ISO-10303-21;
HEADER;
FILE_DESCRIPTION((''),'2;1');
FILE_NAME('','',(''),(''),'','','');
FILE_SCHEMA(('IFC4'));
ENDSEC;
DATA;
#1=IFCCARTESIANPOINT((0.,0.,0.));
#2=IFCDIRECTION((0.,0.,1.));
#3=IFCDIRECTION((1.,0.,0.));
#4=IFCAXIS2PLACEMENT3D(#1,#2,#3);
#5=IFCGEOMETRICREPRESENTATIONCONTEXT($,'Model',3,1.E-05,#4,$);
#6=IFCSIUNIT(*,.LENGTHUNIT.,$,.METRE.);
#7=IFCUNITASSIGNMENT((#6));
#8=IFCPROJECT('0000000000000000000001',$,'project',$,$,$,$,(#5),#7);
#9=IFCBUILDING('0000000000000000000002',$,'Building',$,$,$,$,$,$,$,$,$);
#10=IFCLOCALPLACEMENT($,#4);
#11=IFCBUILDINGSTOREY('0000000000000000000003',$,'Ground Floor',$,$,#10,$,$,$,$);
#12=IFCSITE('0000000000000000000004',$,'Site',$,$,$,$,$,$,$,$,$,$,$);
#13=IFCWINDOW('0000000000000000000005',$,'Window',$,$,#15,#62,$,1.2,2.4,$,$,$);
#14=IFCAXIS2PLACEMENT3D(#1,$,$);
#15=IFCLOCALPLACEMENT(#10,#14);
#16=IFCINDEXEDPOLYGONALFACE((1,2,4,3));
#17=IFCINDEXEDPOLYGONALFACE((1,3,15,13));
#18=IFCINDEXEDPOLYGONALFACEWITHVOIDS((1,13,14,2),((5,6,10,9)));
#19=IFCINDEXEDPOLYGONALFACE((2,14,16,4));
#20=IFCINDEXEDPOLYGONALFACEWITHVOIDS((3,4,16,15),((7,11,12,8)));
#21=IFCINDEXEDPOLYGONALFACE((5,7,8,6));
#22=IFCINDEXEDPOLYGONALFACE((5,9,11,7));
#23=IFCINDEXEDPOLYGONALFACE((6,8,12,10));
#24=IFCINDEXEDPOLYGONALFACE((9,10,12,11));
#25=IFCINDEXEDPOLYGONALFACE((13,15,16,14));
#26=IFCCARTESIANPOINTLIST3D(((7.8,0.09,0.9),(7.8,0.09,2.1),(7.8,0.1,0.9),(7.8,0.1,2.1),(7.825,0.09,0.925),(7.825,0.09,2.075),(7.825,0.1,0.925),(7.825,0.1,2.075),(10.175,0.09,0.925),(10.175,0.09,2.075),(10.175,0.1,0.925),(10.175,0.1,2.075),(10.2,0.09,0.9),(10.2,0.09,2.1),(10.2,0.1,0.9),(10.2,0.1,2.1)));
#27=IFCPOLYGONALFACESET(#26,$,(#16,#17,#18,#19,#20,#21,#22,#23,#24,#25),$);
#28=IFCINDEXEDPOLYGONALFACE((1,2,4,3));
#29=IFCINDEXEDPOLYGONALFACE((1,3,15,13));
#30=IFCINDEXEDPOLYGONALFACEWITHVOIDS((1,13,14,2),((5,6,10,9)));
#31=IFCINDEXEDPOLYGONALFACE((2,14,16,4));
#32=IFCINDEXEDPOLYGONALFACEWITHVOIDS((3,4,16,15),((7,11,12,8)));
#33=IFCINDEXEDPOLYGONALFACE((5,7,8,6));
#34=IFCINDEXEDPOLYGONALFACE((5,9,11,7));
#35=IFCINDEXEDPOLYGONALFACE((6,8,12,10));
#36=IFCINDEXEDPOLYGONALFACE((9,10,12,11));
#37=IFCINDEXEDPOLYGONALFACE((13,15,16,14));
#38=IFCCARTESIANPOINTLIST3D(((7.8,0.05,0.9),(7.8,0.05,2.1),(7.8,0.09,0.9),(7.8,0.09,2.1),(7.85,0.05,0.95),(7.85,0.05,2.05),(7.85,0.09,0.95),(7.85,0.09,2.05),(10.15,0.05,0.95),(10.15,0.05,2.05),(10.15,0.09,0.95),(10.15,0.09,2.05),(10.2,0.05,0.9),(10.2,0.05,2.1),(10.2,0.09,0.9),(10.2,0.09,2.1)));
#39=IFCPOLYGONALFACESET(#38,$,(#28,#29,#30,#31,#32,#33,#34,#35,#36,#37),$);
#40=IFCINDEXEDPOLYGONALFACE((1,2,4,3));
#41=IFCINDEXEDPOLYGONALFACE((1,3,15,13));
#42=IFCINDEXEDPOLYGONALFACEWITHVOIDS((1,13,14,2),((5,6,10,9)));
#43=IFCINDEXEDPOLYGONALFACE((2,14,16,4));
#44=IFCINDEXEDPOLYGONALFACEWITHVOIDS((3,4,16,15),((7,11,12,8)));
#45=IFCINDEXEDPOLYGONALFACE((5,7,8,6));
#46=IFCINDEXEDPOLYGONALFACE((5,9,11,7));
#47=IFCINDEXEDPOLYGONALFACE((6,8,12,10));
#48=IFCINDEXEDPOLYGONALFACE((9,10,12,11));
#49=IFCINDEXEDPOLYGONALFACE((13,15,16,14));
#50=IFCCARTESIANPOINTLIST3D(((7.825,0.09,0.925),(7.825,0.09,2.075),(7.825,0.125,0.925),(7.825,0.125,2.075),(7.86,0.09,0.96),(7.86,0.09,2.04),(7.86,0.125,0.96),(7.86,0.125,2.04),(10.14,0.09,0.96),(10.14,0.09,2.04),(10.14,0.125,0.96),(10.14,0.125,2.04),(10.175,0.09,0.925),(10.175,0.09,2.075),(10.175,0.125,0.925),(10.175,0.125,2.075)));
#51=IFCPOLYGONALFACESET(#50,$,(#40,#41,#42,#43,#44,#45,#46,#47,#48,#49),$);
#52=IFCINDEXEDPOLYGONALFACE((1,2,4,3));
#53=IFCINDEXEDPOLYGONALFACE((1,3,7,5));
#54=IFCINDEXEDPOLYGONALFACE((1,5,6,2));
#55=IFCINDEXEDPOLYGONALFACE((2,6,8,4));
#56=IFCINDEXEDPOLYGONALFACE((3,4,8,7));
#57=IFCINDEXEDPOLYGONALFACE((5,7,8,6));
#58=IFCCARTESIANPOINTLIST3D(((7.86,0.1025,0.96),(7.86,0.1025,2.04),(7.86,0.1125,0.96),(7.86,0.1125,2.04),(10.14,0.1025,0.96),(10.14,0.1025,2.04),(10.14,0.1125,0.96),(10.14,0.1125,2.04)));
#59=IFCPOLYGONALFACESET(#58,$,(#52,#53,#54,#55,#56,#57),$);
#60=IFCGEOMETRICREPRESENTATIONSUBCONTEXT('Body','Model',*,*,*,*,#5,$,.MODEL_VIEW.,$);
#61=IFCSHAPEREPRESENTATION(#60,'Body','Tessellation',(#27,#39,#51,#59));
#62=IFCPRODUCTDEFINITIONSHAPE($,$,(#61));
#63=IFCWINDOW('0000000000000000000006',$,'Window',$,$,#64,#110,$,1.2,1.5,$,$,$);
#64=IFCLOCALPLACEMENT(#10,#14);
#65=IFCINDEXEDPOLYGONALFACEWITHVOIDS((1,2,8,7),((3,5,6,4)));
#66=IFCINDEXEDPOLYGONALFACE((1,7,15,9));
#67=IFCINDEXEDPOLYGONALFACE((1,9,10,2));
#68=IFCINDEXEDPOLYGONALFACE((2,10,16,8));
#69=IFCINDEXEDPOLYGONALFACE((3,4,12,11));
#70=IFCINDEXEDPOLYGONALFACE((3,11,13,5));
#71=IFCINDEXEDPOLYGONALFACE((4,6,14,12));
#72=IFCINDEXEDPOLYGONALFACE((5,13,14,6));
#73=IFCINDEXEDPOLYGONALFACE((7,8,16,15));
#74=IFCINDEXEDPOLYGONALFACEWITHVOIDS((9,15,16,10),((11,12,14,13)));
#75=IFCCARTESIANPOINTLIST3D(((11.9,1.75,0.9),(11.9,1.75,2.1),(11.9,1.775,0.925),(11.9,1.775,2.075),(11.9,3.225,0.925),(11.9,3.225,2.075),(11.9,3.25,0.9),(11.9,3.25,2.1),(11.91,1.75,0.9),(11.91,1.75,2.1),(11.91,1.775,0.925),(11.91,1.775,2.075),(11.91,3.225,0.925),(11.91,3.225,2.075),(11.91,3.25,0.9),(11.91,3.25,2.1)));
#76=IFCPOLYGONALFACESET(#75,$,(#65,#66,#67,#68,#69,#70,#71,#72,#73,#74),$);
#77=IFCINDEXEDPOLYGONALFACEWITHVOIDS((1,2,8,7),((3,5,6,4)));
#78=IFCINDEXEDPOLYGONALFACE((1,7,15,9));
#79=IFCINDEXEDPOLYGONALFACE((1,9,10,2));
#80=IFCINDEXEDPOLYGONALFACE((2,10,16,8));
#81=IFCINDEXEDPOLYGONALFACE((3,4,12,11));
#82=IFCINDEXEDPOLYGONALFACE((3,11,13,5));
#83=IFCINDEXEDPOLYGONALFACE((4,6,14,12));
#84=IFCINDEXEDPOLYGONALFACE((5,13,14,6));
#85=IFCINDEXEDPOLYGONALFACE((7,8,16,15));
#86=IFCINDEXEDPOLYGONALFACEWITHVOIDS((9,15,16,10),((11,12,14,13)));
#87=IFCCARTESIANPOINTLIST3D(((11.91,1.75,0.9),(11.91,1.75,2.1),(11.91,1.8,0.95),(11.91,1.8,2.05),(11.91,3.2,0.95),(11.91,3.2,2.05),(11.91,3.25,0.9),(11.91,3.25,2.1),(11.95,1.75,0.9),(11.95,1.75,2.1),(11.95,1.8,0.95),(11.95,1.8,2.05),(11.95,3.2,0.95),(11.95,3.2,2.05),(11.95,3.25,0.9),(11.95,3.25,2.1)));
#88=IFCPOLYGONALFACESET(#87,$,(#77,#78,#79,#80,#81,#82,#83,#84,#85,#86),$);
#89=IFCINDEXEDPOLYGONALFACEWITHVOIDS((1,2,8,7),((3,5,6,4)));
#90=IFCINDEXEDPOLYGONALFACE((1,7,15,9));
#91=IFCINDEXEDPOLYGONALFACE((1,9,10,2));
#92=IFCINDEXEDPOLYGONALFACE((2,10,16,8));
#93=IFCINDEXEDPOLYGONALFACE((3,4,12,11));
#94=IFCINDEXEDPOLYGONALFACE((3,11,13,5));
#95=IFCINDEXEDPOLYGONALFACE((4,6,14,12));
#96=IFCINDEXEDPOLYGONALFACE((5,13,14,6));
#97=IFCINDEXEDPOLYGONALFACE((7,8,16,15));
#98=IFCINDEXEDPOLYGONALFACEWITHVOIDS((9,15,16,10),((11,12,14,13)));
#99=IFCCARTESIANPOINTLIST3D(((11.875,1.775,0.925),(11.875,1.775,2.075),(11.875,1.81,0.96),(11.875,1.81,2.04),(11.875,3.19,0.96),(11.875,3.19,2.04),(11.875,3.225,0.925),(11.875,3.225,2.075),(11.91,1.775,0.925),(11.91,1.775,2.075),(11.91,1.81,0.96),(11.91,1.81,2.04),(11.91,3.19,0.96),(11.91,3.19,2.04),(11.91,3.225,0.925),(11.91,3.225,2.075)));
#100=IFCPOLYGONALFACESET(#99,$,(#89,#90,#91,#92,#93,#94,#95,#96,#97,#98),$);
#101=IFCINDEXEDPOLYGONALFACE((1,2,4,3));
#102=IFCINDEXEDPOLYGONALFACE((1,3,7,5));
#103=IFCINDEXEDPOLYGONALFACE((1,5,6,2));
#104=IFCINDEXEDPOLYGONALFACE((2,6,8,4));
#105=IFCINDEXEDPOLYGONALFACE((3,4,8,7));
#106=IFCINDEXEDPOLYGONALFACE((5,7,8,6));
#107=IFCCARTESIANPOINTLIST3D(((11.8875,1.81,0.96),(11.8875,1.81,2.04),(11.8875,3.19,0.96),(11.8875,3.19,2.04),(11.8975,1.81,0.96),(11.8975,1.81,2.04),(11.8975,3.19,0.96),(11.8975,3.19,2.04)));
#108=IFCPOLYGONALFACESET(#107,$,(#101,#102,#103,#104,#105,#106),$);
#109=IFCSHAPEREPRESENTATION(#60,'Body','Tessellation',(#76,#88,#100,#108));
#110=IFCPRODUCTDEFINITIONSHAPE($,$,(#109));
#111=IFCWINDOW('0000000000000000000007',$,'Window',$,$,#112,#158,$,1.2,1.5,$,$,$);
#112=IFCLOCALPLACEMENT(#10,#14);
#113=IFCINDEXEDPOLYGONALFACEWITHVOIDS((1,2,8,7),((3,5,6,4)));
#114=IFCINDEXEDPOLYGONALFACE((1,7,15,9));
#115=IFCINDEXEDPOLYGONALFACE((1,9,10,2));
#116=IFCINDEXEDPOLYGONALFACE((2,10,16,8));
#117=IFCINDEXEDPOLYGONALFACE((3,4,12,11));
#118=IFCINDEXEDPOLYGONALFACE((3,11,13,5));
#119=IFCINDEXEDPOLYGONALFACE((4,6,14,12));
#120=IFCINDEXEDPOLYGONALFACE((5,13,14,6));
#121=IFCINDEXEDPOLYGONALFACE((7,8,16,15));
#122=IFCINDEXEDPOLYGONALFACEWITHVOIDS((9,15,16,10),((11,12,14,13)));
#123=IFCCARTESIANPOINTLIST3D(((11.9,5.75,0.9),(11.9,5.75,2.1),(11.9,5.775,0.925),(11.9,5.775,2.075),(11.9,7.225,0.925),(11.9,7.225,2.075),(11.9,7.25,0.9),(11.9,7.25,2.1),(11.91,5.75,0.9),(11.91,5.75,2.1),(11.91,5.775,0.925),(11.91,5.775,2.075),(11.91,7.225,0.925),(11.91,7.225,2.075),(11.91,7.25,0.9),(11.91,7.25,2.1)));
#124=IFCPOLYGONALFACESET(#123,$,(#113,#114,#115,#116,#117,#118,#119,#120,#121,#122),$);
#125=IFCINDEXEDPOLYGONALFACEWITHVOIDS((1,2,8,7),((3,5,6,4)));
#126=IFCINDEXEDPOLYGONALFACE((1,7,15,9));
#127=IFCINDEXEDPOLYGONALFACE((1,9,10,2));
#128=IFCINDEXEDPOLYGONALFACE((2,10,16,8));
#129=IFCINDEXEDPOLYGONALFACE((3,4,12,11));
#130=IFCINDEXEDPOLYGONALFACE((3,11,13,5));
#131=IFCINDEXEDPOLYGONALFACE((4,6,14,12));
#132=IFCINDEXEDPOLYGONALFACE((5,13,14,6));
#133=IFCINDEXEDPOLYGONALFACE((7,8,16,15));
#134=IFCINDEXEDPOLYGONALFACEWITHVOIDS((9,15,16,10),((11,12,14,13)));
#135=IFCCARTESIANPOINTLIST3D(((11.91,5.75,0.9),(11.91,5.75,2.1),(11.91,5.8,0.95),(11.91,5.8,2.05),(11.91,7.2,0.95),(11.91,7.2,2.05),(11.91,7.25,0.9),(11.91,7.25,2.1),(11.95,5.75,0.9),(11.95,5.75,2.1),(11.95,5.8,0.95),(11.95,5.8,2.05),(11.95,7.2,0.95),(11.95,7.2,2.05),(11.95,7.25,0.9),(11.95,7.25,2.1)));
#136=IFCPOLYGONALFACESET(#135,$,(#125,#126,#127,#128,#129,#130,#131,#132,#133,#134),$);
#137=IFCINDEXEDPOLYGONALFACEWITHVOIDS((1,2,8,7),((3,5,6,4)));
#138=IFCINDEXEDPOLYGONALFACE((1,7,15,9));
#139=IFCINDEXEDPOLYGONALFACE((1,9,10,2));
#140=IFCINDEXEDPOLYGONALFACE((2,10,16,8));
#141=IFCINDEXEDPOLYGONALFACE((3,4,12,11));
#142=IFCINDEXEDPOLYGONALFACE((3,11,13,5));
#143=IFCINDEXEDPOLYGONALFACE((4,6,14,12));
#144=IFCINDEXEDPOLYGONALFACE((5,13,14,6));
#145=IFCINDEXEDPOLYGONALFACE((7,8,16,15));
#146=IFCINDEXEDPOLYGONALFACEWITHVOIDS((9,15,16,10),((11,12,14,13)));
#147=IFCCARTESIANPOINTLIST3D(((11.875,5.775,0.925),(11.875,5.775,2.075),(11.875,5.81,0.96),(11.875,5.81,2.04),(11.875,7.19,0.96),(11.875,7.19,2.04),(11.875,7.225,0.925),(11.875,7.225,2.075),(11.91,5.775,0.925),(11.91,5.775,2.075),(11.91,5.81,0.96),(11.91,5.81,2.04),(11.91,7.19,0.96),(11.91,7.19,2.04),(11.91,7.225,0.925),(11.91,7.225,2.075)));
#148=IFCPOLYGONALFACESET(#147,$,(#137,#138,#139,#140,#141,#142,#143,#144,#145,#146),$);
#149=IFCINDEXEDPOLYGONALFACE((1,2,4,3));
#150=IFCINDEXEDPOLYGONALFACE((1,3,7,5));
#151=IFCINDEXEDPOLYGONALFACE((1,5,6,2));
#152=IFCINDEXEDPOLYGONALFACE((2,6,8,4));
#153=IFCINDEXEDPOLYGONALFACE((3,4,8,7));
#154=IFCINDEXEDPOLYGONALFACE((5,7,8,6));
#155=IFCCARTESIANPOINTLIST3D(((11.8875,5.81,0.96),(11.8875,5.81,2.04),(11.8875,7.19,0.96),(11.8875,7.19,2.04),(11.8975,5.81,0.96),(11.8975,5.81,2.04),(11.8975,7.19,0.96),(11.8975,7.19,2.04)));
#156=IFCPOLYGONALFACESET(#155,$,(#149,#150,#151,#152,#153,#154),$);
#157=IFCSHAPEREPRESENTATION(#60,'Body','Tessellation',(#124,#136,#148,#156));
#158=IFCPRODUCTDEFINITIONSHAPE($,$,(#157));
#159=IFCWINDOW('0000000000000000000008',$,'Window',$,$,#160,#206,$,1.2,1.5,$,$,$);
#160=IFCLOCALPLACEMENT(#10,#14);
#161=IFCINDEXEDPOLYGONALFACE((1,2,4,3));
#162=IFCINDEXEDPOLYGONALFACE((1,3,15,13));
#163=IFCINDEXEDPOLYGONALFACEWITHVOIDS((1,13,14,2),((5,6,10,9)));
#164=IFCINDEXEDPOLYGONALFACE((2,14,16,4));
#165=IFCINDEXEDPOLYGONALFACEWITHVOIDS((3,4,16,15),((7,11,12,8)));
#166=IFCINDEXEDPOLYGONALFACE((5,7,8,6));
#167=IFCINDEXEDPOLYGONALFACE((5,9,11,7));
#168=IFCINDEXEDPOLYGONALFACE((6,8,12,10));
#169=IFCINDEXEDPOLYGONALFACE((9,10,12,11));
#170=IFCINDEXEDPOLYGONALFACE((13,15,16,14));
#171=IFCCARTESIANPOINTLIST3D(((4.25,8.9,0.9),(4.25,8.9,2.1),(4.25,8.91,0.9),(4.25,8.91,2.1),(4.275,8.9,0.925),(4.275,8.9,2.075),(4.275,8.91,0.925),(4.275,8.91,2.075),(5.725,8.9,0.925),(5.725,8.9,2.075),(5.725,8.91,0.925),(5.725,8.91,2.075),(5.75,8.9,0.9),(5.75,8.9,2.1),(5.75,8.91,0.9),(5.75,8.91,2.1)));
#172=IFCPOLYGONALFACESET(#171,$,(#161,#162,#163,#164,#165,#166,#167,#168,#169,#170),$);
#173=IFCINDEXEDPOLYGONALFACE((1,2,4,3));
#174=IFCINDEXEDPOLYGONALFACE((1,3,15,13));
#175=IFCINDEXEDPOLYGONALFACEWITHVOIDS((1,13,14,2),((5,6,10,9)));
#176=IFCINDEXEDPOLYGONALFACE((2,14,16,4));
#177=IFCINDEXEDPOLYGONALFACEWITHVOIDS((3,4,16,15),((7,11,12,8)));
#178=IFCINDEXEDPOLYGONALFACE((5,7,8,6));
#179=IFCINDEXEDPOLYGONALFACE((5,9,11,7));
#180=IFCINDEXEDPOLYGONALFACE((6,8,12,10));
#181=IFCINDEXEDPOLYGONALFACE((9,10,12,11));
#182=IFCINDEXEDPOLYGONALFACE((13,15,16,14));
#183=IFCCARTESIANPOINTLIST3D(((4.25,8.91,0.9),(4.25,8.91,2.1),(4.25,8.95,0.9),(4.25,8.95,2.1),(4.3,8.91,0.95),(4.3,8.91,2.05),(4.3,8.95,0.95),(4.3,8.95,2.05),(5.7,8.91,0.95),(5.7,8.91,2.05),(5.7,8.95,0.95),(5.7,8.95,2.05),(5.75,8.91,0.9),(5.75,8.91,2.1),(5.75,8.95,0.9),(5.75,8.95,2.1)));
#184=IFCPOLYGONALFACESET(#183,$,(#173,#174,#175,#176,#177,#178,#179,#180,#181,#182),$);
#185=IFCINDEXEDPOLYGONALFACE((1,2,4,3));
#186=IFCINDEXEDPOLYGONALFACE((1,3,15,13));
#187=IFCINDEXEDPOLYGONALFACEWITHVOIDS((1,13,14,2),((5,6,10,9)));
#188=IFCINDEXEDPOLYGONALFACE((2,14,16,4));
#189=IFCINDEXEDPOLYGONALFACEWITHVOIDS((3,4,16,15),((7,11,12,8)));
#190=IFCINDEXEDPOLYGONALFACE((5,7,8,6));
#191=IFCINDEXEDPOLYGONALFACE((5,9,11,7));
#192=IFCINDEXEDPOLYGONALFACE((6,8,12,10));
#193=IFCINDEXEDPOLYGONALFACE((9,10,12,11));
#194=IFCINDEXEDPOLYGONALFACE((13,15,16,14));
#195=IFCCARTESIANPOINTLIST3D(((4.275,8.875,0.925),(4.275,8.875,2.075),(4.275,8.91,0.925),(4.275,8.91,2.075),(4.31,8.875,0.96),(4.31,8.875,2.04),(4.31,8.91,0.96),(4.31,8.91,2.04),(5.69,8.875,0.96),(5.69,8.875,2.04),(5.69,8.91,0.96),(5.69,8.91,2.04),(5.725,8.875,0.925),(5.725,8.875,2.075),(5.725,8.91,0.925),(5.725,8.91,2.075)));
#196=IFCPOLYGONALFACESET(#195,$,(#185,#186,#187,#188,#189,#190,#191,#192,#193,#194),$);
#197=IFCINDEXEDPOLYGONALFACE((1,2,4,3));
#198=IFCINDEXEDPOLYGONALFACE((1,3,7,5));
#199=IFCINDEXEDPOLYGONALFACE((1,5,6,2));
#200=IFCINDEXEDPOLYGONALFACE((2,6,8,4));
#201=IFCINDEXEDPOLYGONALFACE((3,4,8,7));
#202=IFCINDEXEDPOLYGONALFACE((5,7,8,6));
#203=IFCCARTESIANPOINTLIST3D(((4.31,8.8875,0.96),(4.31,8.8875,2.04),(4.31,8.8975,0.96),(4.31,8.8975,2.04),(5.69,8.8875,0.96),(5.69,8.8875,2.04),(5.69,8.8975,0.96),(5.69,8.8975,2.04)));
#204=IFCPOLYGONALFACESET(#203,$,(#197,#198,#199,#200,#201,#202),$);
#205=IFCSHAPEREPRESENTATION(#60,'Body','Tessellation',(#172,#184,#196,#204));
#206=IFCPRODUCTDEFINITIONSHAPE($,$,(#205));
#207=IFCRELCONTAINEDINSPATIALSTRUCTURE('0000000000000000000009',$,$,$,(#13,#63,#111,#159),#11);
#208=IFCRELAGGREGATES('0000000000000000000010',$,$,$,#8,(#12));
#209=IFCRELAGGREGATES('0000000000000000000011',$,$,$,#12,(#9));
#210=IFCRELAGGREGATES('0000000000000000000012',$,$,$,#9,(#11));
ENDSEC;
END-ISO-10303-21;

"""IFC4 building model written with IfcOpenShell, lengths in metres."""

from ifc_helpers import new_model, si_unit, frame, origin_with_axes, place, context, subcontext, project, spatial, line, indexed_curve, outline, extrude, element, save


model = new_model("IFC4")

# Units and contexts
model_context = context("Model", 3, precision=1e-05, world=origin_with_axes())
body_context = subcontext(model_context, "Body", "Model", "MODEL_VIEW")
ifc_project = project(units=[si_unit("LENGTHUNIT", "METRE")], contexts=[model_context])

# Site, building, storey
site = spatial("IfcSite", under=ifc_project, Name="Site")
building = spatial("IfcBuilding", under=site, Name="Building")
storey_placement = place(None, origin_with_axes())
storey = spatial("IfcBuildingStorey", under=building, at=storey_placement, Name="Ground Floor")

# Windows
window_1_placement = place(storey_placement, frame((7.8, 0.0, 0.9), z_axis=(0.0, 0.0, 1.0), x_axis=(1.0, 0.0, 0.0)))
element("IfcWindow", 1, at=window_1_placement, inside=storey, Name="Window", OverallHeight=1.2, OverallWidth=2.4, context=body_context, shape_type="SweptSolid", body=[
    extrude(outline(indexed_curve([(0.0, 0.0), (2.4, 0.0), (2.4, 1.2), (0.0, 1.2)], segments=[line(1, 2, 3, 4, 1)]), holes=[indexed_curve([(0.025, 0.025), (2.375, 0.025), (2.375, 1.175), (0.025, 1.175)], segments=[line(1, 2, 3, 4, 1)])]), frame((0.0, 0.09, 0.0), z_axis=(0.0, -1.0, 0.0), x_axis=(1.0, 0.0, 0.0)), (0.0, 0.0, -1.0), 0.01),
    extrude(outline(indexed_curve([(0.0, 0.0), (2.4, 0.0), (2.4, 1.2), (0.0, 1.2)], segments=[line(1, 2, 3, 4, 1)]), holes=[indexed_curve([(0.05, 0.05), (2.35, 0.05), (2.35, 1.15), (0.05, 1.15)], segments=[line(1, 2, 3, 4, 1)])]), frame((0.0, 0.05, 0.0), z_axis=(0.0, -1.0, 0.0), x_axis=(1.0, 0.0, 0.0)), (0.0, 0.0, -1.0), 0.04),
    extrude(outline(indexed_curve([(0.0, 0.0), (2.35, 0.0), (2.35, 1.15), (0.0, 1.15)], segments=[line(1, 2, 3, 4, 1)]), holes=[indexed_curve([(0.035, 0.035), (2.315, 0.035), (2.315, 1.115), (0.035, 1.115)], segments=[line(1, 2, 3, 4, 1)])]), frame((0.025, 0.09, 0.025), z_axis=(0.0, -1.0, 0.0), x_axis=(1.0, 0.0, 0.0)), (0.0, 0.0, -1.0), 0.035),
    extrude(outline(indexed_curve([(0.035, 0.035), (2.315, 0.035), (2.315, 1.115), (0.035, 1.115)], segments=[line(1, 2, 3, 4, 1)])), frame((0.025, 0.1025, 0.025), z_axis=(0.0, -1.0, 0.0), x_axis=(1.0, 0.0, 0.0)), (0.0, 0.0, -1.0), 0.01),
])
for number, where, z_axis, x_axis, name in (
    (2, (12.0, 1.75, 0.9), (0.0, 0.0, 1.0), (0.0, 1.0, 0.0), "Window"),
    (3, (12.0, 5.75, 0.9), (0.0, 0.0, 1.0), (0.0, 1.0, 0.0), "Window"),
    (4, (5.75, 9.0, 0.9), (0.0, 0.0, 1.0), (-1.0, 0.0, 0.0), "Window"),
):
    element("IfcWindow", number, at=place(storey_placement, frame(where, z_axis=z_axis, x_axis=x_axis)), inside=storey, Name=name, OverallHeight=1.2, OverallWidth=1.5, context=body_context, shape_type="SweptSolid", body=[
        extrude(outline(indexed_curve([(0.0, 0.0), (1.5, 0.0), (1.5, 1.2), (0.0, 1.2)], segments=[line(1, 2, 3, 4, 1)]), holes=[indexed_curve([(0.025, 0.025), (1.475, 0.025), (1.475, 1.175), (0.025, 1.175)], segments=[line(1, 2, 3, 4, 1)])]), frame((0.0, 0.09, 0.0), z_axis=(0.0, -1.0, 0.0), x_axis=(1.0, 0.0, 0.0)), (0.0, 0.0, -1.0), 0.01),
        extrude(outline(indexed_curve([(0.0, 0.0), (1.5, 0.0), (1.5, 1.2), (0.0, 1.2)], segments=[line(1, 2, 3, 4, 1)]), holes=[indexed_curve([(0.05, 0.05), (1.45, 0.05), (1.45, 1.15), (0.05, 1.15)], segments=[line(1, 2, 3, 4, 1)])]), frame((0.0, 0.05, 0.0), z_axis=(0.0, -1.0, 0.0), x_axis=(1.0, 0.0, 0.0)), (0.0, 0.0, -1.0), 0.04),
        extrude(outline(indexed_curve([(0.0, 0.0), (1.45, 0.0), (1.45, 1.15), (0.0, 1.15)], segments=[line(1, 2, 3, 4, 1)]), holes=[indexed_curve([(0.035, 0.035), (1.415, 0.035), (1.415, 1.115), (0.035, 1.115)], segments=[line(1, 2, 3, 4, 1)])]), frame((0.025, 0.09, 0.025), z_axis=(0.0, -1.0, 0.0), x_axis=(1.0, 0.0, 0.0)), (0.0, 0.0, -1.0), 0.035),
        extrude(outline(indexed_curve([(0.035, 0.035), (1.415, 0.035), (1.415, 1.115), (0.035, 1.115)], segments=[line(1, 2, 3, 4, 1)])), frame((0.025, 0.1025, 0.025), z_axis=(0.0, -1.0, 0.0), x_axis=(1.0, 0.0, 0.0)), (0.0, 0.0, -1.0), 0.01),
    ])

save(model, "model.ifc")
